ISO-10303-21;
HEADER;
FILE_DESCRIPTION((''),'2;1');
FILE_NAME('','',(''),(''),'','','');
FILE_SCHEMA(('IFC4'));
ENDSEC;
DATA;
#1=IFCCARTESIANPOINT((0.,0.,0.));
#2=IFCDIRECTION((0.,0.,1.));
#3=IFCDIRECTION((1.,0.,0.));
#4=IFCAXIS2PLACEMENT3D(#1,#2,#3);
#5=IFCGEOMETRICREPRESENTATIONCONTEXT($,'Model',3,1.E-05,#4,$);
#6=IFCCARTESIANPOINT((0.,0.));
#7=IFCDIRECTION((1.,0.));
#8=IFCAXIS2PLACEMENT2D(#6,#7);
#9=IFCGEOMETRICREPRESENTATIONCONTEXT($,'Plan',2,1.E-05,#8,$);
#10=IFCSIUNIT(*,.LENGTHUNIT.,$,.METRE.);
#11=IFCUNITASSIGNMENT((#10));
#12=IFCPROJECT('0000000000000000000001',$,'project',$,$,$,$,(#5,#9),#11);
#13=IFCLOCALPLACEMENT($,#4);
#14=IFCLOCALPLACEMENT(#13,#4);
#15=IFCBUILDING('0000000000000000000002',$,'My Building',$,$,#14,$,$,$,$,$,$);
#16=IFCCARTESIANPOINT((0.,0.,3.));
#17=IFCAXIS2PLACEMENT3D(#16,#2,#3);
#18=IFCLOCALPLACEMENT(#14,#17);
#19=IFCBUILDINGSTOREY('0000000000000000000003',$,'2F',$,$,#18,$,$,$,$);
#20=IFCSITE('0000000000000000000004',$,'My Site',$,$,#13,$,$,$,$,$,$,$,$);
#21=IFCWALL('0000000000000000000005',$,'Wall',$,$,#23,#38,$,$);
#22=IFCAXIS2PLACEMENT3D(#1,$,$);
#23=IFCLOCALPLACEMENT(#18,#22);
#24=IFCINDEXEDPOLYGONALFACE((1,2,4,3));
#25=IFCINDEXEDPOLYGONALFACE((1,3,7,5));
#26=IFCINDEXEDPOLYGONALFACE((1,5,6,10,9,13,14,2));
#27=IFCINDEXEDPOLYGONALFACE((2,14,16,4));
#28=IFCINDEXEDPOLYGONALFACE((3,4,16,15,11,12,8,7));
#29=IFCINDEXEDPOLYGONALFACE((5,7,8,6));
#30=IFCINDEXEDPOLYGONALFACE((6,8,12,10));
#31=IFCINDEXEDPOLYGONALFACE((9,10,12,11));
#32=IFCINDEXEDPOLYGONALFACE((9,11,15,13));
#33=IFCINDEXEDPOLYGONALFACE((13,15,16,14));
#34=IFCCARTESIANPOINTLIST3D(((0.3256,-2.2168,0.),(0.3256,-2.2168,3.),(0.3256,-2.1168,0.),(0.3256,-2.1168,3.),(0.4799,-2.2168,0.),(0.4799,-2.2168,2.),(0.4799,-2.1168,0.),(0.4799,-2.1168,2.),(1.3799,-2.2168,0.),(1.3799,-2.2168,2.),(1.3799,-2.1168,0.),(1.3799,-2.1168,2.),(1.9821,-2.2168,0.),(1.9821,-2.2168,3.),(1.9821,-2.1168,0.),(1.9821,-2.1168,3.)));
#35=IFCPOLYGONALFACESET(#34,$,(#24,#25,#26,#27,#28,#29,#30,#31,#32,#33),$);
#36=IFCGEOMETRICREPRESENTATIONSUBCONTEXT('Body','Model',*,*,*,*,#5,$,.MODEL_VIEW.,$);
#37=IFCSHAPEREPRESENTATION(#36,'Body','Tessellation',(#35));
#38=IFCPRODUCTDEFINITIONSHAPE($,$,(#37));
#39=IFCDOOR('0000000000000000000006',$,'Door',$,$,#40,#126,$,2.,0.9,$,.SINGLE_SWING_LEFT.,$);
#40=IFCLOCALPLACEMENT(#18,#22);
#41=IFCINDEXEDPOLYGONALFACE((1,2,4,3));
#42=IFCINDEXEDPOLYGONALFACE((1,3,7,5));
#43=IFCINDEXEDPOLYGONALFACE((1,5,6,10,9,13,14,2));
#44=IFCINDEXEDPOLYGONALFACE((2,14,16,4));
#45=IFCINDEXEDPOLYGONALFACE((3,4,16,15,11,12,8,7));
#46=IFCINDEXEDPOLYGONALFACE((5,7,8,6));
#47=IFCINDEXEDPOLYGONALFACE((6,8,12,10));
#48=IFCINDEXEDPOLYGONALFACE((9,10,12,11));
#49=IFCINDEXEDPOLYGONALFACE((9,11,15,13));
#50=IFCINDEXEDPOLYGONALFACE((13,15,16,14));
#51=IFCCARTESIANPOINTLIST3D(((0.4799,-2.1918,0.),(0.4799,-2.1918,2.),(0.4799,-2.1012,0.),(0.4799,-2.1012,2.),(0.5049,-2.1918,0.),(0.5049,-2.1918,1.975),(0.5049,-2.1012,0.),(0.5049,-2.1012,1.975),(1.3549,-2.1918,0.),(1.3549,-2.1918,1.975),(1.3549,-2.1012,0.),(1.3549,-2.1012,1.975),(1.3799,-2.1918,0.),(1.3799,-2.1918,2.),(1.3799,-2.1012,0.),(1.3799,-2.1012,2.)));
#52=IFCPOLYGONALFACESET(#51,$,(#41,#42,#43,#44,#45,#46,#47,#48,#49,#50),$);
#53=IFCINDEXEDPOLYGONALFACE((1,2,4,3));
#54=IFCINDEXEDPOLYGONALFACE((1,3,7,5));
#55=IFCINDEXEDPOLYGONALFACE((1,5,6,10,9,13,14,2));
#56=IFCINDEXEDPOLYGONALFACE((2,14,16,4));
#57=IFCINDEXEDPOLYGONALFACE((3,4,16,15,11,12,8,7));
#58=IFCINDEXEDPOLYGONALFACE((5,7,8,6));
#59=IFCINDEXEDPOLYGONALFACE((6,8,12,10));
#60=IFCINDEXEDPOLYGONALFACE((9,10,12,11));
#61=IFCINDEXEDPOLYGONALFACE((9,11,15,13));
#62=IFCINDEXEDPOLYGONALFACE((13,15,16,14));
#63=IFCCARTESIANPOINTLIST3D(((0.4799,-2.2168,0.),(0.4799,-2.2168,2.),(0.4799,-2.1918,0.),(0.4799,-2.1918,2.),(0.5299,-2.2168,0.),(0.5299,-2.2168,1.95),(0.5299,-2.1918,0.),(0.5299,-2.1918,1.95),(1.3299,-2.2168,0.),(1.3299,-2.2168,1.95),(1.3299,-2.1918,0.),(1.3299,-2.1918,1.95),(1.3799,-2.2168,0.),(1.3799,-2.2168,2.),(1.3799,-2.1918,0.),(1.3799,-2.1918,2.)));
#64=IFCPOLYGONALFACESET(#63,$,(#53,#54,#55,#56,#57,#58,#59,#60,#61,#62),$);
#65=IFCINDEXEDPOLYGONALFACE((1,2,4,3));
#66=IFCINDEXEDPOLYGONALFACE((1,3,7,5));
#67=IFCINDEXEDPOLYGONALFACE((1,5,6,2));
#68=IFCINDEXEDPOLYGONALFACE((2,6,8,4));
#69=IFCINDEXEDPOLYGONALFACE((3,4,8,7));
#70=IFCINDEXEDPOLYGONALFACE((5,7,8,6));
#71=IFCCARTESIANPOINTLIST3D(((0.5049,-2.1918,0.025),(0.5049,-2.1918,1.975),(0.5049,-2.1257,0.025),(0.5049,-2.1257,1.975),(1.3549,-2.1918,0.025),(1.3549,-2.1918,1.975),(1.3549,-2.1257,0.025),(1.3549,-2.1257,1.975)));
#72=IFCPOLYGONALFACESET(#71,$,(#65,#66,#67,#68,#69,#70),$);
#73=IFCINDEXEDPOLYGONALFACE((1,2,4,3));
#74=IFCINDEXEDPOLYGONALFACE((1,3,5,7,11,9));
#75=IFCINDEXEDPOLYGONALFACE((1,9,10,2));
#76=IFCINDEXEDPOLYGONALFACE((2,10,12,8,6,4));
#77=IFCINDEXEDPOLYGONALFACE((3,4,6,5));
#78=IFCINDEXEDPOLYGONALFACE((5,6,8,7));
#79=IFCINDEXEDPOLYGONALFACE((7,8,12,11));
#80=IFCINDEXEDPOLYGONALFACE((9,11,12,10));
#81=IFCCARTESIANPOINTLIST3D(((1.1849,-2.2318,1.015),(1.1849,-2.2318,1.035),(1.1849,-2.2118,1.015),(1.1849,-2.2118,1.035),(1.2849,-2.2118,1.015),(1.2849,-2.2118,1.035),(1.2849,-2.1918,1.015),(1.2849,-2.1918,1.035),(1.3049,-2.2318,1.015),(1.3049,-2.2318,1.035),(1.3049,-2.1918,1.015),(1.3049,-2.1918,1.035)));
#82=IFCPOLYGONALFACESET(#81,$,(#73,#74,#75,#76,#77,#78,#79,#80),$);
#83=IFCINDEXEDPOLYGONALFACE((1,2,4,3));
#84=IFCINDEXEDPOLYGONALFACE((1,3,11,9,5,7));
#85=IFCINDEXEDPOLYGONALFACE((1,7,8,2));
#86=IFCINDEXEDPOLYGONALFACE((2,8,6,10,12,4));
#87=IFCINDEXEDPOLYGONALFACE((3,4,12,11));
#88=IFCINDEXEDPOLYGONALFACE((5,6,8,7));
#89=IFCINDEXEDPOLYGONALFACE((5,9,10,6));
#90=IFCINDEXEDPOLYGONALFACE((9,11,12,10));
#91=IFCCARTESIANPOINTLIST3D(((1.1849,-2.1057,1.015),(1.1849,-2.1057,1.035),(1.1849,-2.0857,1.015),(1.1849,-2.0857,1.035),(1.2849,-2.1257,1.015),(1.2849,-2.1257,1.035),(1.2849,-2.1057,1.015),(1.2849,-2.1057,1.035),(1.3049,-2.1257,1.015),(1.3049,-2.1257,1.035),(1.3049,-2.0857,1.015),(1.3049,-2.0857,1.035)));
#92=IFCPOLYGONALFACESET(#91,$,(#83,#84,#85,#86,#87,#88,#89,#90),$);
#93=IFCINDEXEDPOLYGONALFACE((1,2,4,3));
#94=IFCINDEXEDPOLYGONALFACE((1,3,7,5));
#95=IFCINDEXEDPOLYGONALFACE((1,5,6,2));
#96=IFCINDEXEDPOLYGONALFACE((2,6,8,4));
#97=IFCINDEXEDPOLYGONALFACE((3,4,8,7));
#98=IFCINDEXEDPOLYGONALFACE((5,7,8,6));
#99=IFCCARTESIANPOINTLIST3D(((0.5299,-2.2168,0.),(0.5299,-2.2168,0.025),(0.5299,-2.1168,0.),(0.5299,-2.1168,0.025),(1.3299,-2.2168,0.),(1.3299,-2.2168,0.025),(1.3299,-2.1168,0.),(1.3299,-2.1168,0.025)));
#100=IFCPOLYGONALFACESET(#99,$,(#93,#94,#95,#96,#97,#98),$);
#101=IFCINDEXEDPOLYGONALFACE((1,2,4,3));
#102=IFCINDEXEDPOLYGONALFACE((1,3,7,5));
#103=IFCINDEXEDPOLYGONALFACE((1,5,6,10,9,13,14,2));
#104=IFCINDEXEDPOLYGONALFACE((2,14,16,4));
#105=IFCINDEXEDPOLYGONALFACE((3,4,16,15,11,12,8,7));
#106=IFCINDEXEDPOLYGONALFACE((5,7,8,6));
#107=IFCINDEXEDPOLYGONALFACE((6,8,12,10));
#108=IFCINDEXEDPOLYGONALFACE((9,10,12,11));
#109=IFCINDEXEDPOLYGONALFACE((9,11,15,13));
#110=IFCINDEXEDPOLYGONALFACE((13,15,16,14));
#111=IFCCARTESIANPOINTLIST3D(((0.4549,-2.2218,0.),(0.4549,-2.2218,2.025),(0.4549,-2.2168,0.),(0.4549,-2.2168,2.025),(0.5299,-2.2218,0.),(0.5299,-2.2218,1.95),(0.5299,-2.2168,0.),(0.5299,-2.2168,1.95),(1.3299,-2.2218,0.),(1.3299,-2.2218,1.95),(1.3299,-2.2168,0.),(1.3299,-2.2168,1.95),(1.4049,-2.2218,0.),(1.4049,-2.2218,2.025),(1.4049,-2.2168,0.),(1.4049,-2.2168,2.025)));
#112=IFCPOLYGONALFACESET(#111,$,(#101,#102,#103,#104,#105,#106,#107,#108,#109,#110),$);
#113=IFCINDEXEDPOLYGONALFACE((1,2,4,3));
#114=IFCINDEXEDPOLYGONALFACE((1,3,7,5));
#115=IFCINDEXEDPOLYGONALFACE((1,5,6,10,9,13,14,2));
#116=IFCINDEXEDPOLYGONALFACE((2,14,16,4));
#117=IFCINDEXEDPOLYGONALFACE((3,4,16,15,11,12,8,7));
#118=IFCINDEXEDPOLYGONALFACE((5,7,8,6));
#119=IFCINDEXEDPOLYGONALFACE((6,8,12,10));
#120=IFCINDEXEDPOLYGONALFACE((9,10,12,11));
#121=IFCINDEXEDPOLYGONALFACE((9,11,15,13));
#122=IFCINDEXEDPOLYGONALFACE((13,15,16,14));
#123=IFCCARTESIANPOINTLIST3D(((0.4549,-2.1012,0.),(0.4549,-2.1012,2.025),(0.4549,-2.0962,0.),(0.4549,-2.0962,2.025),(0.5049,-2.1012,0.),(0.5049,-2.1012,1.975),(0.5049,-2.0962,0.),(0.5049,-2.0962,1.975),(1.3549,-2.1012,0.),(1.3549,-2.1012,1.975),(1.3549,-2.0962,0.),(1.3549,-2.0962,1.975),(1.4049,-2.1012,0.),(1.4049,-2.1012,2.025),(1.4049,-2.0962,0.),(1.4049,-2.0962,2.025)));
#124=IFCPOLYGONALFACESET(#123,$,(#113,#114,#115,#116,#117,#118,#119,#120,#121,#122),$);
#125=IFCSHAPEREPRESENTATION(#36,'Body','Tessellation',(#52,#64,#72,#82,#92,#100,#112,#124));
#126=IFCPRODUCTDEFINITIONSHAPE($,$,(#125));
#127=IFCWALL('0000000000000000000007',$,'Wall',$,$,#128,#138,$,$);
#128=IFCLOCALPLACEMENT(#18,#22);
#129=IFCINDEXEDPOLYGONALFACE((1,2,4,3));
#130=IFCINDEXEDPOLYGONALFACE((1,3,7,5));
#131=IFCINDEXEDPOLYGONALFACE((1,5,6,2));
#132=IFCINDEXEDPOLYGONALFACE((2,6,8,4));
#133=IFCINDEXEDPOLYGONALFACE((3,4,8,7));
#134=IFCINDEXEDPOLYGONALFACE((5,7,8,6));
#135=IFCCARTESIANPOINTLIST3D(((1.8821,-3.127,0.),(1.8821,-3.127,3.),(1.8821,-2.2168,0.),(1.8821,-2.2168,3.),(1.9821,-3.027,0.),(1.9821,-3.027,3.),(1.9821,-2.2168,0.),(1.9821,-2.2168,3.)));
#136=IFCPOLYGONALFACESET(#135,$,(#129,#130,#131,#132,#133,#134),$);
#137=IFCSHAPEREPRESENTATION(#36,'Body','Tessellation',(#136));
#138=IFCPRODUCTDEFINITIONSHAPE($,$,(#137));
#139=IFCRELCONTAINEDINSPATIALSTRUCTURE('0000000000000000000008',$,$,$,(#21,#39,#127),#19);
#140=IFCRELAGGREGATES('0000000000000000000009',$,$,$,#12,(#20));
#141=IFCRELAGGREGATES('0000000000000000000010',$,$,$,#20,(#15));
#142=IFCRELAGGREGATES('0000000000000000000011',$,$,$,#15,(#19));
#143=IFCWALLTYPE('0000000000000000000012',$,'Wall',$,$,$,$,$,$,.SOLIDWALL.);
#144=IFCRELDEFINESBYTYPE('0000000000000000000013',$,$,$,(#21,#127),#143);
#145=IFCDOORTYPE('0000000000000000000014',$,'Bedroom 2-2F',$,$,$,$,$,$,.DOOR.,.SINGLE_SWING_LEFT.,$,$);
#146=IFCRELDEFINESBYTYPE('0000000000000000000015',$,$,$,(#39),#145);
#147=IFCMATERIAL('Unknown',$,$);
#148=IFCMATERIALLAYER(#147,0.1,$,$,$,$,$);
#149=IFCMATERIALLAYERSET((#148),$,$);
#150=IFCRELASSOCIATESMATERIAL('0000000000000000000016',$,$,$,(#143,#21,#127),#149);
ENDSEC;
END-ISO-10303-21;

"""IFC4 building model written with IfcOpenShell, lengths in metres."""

from ifc_helpers import new_model, entity, si_unit, frame, origin_with_axes, origin_2d_with_axis, place, context, subcontext, project, spatial, line, indexed_curve, outline, extrude, shape, source, transform, mapped, material, layer, layer_set, layer_usage, type_object, type_shapes, element, fill, save


model = new_model("IFC4")

# Units and contexts
model_context = context("Model", 3, precision=1e-05, world=origin_with_axes())
plan_context = context("Plan", 2, precision=1e-05, world=origin_2d_with_axis())
body_context_1 = subcontext(model_context, "Body", "Model", "MODEL_VIEW")
body_context_2 = subcontext(plan_context, "Body", "Plan", "PLAN_VIEW")
ifc_project = project(units=[si_unit("LENGTHUNIT", "METRE")], contexts=[model_context, plan_context])

# Site, building, storey
site_placement = place(None, origin_with_axes())
site = spatial("IfcSite", under=ifc_project, at=site_placement, Name="My Site")
building_placement = place(site_placement, origin_with_axes())
building = spatial("IfcBuilding", under=site, at=building_placement, Name="My Building")
storey_placement = place(building_placement, frame((0.0, 0.0, 3.0), z_axis=(0.0, 0.0, 1.0), x_axis=(1.0, 0.0, 0.0)))
storey = spatial("IfcBuildingStorey", under=building, at=storey_placement, Name="2F")

# Shared definitions
ifc_material = material(Name="Unknown")

# Shared definitions
ifc_layer_1 = layer(ifc_material, 0.1)
ifc_layer_set_1 = layer_set([ifc_layer_1])
wall_type = type_object("IfcWallType", Name="Wall", PredefinedType="SOLIDWALL", material=ifc_layer_set_1)

# Wall, opening, door
ifc_layer_usage_1 = layer_usage(ifc_layer_set_1, "AXIS2", "POSITIVE", 0.0)
wall_1_placement = place(storey_placement, frame((0.3256, -2.2168, 0.0), z_axis=(0.0, 0.0, 1.0), x_axis=(1.0, 0.0, 0.0)))
wall_1 = element("IfcWall", 1, at=wall_1_placement, inside=storey, type_object=wall_type, material=ifc_layer_usage_1, Name="Wall", context=body_context_1, shape_type="SweptSolid", body=[
    extrude(outline(indexed_curve([(0.0, 0.0), (0.0, 0.1), (1.6565, 0.1), (1.6565, 0.0)], segments=[line(1, 2, 3, 4, 1)])), origin_with_axes(), (0.0, 0.0, 1.0), 3.0),
])
shared_shape_1 = source(origin_with_axes(), body_context_1, "Body", "SweptSolid", [
    extrude(outline(indexed_curve([(0.0, 0.0), (0.9, 0.0), (0.9, 2.0), (0.0, 2.0)], segments=[line(1, 2, 3, 4, 1)])), frame((0.0, -0.6, 0.0), z_axis=(0.0, -1.0, 0.0), x_axis=(1.0, 0.0, 0.0)), (0.0, 0.0, -1.0), 1.2),
])
opening_1_placement = place(wall_1_placement, frame((0.1543, 0.0, 0.0), z_axis=(0.0, 0.0, 1.0), x_axis=(1.0, 0.0, 0.0)))
opening_1 = element("IfcOpeningElement", 2, at=opening_1_placement, cuts=wall_1, PredefinedType="OPENING", context=body_context_1, shape_type="MappedRepresentation", body=[
    mapped(shared_shape_1, transform((0.0, 0.0, 0.0), x_axis=(1.0, 0.0, 0.0), y_axis=(0.0, 1.0, 0.0), z_axis=(0.0, 0.0, 1.0), scale=1.0)),
])
door_type_1 = type_object("IfcDoorType", Name="Bedroom 2-2F", OperationType="SINGLE_SWING_LEFT", PredefinedType="DOOR")
shared_shape_2 = source(origin_with_axes(), body_context_1, "Body", "SweptSolid", [
    extrude(outline(indexed_curve([(0.0, 0.0), (0.0, 2.0), (0.9, 2.0), (0.9, 0.0), (0.875, 0.0), (0.875, 1.975), (0.025, 1.975), (0.025, 0.0)], segments=[line(1, 2, 3, 4, 5, 6, 7, 8, 1)])), frame((0.0, 0.025, 0.0), z_axis=(0.0, -1.0, 0.0), x_axis=(1.0, 0.0, 0.0)), (0.0, 0.0, -1.0), 0.0906),
    extrude(outline(indexed_curve([(0.0, 0.0), (0.0, 2.0), (0.9, 2.0), (0.9, 0.0), (0.85, 0.0), (0.85, 1.95), (0.05, 1.95), (0.05, 0.0)], segments=[line(1, 2, 3, 4, 5, 6, 7, 8, 1)])), frame((0.0, 0.0, 0.0), z_axis=(0.0, -1.0, 0.0), x_axis=(1.0, 0.0, 0.0)), (0.0, 0.0, -1.0), 0.025),
    extrude(outline(indexed_curve([(0.0, 0.0), (0.85, 0.0), (0.85, 0.0661), (0.0, 0.0661)], segments=[line(1, 2, 3, 4, 1)])), frame((0.025, 0.025, 0.025), z_axis=(0.0, 0.0, 1.0), x_axis=(1.0, 0.0, 0.0)), (0.0, 0.0, 1.0), 1.95),
    extrude(outline(indexed_curve([(0.0, 0.0), (0.0, -0.04), (-0.12, -0.04), (-0.12, -0.02), (-0.02, -0.02), (-0.02, 0.0)], segments=[line(1, 2, 3, 4, 5, 6, 1)])), frame((0.825, 0.025, 1.015), z_axis=(0.0, 0.0, 1.0), x_axis=(1.0, 0.0, 0.0)), (0.0, 0.0, 1.0), 0.02),
    extrude(outline(indexed_curve([(0.0, 0.0), (0.0, 0.04), (-0.12, 0.04), (-0.12, 0.02), (-0.02, 0.02), (-0.02, 0.0)], segments=[line(1, 2, 3, 4, 5, 6, 1)])), frame((0.825, 0.0911, 1.015), z_axis=(0.0, 0.0, 1.0), x_axis=(1.0, 0.0, 0.0)), (0.0, 0.0, 1.0), 0.02),
    extrude(outline(indexed_curve([(0.0, 0.0), (0.8, 0.0), (0.8, 0.1), (0.0, 0.1)], segments=[line(1, 2, 3, 4, 1)])), frame((0.05, 0.0, 0.0), z_axis=(0.0, 0.0, 1.0), x_axis=(1.0, 0.0, 0.0)), (0.0, 0.0, 1.0), 0.025),
    extrude(outline(indexed_curve([(0.0, 0.0), (0.0, 2.025), (0.95, 2.025), (0.95, 0.0), (0.875, 0.0), (0.875, 1.95), (0.075, 1.95), (0.075, 0.0)], segments=[line(1, 2, 3, 4, 5, 6, 7, 8, 1)])), frame((-0.025, -0.005, 0.0), z_axis=(0.0, -1.0, 0.0), x_axis=(1.0, 0.0, 0.0)), (0.0, 0.0, -1.0), 0.005),
    extrude(outline(indexed_curve([(0.0, 0.0), (0.0, 2.025), (0.95, 2.025), (0.95, 0.0), (0.9, 0.0), (0.9, 1.975), (0.05, 1.975), (0.05, 0.0)], segments=[line(1, 2, 3, 4, 5, 6, 7, 8, 1)])), frame((-0.025, 0.1156, 0.0), z_axis=(0.0, -1.0, 0.0), x_axis=(1.0, 0.0, 0.0)), (0.0, 0.0, -1.0), 0.005),
])
shared_shape_3 = source(origin_with_axes(), body_context_2, "Body", "Curve2D", [
    entity("IfcIndexedPolyCurve", entity("IfcCartesianPointList2D", [[0.0, 0.0], [0.0, 0.1156], [0.025, 0.1156], [0.025, 0.025], [0.05, 0.025], [0.05, 0.0]]), [entity("IfcLineIndex", [1, 2, 3, 4, 5, 6, 1])]),
    entity("IfcIndexedPolyCurve", entity("IfcCartesianPointList2D", [[0.9, 0.0], [0.9, 0.1156], [0.875, 0.1156], [0.875, 0.025], [0.85, 0.025], [0.85, 0.0]]), [entity("IfcLineIndex", [1, 2, 3, 4, 5, 6, 1])]),
    entity("IfcTrimmedCurve", entity("IfcEllipse", entity("IfcAxis2Placement2D", entity("IfcCartesianPoint", [0.0911, 0.1156]), entity("IfcDirection", [1.0, 0.0])), 0.7839, 0.85), [entity("IfcCartesianPoint", [0.875, 0.1156])], [entity("IfcCartesianPoint", [0.0911, 0.9656])], True, "CARTESIAN"),
    entity("IfcIndexedPolyCurve", entity("IfcCartesianPointList2D", [[0.025, 0.1156], [0.0911, 0.1156], [0.0911, 0.9656], [0.025, 0.9656]]), [entity("IfcLineIndex", [1, 2, 3, 4, 1])]),
])
type_shapes(door_type_1, [shared_shape_2, shared_shape_3])
door_1_placement = place(opening_1_placement, frame((0.0, 0.0, 0.0), z_axis=(0.0, 0.0, 1.0), x_axis=(1.0, 0.0, 0.0)))
door_1 = element("IfcDoor", 3, at=door_1_placement, inside=storey, type_object=door_type_1, Name="Door", OperationType="SINGLE_SWING_LEFT", OverallHeight=2.0, OverallWidth=0.9, shapes=[
    shape(body_context_1, "Body", "MappedRepresentation", [mapped(shared_shape_2, transform((0.0, 0.0, 0.0), x_axis=(1.0, 0.0, 0.0), y_axis=(0.0, 1.0, 0.0), z_axis=(0.0, 0.0, 1.0), scale=1.0))]),
    shape(body_context_2, "Body", "MappedRepresentation", [mapped(shared_shape_3, transform((0.0, 0.0, 0.0), x_axis=(1.0, 0.0, 0.0), y_axis=(0.0, 1.0, 0.0), z_axis=(0.0, 0.0, 1.0), scale=1.0))]),
])
fill(opening_1, door_1)

# Wall
ifc_layer_usage_2 = layer_usage(ifc_layer_set_1, "AXIS2", "POSITIVE", 0.0)
wall_2_placement = place(storey_placement, frame((1.8821, -2.2168, 0.0), z_axis=(0.0, 0.0, 1.0), x_axis=(0.0, -1.0, 0.0)))
element("IfcWall", 4, at=wall_2_placement, inside=storey, type_object=wall_type, material=ifc_layer_usage_2, Name="Wall", context=body_context_1, shape_type="SweptSolid", body=[
    extrude(outline(indexed_curve([(0.0, 0.0), (0.0, 0.1), (0.8102, 0.1), (0.9102, 0.0)], segments=[line(1, 2, 3, 4, 1)])), origin_with_axes(), (0.0, 0.0, 1.0), 3.0),
])

save(model, "model.ifc")
